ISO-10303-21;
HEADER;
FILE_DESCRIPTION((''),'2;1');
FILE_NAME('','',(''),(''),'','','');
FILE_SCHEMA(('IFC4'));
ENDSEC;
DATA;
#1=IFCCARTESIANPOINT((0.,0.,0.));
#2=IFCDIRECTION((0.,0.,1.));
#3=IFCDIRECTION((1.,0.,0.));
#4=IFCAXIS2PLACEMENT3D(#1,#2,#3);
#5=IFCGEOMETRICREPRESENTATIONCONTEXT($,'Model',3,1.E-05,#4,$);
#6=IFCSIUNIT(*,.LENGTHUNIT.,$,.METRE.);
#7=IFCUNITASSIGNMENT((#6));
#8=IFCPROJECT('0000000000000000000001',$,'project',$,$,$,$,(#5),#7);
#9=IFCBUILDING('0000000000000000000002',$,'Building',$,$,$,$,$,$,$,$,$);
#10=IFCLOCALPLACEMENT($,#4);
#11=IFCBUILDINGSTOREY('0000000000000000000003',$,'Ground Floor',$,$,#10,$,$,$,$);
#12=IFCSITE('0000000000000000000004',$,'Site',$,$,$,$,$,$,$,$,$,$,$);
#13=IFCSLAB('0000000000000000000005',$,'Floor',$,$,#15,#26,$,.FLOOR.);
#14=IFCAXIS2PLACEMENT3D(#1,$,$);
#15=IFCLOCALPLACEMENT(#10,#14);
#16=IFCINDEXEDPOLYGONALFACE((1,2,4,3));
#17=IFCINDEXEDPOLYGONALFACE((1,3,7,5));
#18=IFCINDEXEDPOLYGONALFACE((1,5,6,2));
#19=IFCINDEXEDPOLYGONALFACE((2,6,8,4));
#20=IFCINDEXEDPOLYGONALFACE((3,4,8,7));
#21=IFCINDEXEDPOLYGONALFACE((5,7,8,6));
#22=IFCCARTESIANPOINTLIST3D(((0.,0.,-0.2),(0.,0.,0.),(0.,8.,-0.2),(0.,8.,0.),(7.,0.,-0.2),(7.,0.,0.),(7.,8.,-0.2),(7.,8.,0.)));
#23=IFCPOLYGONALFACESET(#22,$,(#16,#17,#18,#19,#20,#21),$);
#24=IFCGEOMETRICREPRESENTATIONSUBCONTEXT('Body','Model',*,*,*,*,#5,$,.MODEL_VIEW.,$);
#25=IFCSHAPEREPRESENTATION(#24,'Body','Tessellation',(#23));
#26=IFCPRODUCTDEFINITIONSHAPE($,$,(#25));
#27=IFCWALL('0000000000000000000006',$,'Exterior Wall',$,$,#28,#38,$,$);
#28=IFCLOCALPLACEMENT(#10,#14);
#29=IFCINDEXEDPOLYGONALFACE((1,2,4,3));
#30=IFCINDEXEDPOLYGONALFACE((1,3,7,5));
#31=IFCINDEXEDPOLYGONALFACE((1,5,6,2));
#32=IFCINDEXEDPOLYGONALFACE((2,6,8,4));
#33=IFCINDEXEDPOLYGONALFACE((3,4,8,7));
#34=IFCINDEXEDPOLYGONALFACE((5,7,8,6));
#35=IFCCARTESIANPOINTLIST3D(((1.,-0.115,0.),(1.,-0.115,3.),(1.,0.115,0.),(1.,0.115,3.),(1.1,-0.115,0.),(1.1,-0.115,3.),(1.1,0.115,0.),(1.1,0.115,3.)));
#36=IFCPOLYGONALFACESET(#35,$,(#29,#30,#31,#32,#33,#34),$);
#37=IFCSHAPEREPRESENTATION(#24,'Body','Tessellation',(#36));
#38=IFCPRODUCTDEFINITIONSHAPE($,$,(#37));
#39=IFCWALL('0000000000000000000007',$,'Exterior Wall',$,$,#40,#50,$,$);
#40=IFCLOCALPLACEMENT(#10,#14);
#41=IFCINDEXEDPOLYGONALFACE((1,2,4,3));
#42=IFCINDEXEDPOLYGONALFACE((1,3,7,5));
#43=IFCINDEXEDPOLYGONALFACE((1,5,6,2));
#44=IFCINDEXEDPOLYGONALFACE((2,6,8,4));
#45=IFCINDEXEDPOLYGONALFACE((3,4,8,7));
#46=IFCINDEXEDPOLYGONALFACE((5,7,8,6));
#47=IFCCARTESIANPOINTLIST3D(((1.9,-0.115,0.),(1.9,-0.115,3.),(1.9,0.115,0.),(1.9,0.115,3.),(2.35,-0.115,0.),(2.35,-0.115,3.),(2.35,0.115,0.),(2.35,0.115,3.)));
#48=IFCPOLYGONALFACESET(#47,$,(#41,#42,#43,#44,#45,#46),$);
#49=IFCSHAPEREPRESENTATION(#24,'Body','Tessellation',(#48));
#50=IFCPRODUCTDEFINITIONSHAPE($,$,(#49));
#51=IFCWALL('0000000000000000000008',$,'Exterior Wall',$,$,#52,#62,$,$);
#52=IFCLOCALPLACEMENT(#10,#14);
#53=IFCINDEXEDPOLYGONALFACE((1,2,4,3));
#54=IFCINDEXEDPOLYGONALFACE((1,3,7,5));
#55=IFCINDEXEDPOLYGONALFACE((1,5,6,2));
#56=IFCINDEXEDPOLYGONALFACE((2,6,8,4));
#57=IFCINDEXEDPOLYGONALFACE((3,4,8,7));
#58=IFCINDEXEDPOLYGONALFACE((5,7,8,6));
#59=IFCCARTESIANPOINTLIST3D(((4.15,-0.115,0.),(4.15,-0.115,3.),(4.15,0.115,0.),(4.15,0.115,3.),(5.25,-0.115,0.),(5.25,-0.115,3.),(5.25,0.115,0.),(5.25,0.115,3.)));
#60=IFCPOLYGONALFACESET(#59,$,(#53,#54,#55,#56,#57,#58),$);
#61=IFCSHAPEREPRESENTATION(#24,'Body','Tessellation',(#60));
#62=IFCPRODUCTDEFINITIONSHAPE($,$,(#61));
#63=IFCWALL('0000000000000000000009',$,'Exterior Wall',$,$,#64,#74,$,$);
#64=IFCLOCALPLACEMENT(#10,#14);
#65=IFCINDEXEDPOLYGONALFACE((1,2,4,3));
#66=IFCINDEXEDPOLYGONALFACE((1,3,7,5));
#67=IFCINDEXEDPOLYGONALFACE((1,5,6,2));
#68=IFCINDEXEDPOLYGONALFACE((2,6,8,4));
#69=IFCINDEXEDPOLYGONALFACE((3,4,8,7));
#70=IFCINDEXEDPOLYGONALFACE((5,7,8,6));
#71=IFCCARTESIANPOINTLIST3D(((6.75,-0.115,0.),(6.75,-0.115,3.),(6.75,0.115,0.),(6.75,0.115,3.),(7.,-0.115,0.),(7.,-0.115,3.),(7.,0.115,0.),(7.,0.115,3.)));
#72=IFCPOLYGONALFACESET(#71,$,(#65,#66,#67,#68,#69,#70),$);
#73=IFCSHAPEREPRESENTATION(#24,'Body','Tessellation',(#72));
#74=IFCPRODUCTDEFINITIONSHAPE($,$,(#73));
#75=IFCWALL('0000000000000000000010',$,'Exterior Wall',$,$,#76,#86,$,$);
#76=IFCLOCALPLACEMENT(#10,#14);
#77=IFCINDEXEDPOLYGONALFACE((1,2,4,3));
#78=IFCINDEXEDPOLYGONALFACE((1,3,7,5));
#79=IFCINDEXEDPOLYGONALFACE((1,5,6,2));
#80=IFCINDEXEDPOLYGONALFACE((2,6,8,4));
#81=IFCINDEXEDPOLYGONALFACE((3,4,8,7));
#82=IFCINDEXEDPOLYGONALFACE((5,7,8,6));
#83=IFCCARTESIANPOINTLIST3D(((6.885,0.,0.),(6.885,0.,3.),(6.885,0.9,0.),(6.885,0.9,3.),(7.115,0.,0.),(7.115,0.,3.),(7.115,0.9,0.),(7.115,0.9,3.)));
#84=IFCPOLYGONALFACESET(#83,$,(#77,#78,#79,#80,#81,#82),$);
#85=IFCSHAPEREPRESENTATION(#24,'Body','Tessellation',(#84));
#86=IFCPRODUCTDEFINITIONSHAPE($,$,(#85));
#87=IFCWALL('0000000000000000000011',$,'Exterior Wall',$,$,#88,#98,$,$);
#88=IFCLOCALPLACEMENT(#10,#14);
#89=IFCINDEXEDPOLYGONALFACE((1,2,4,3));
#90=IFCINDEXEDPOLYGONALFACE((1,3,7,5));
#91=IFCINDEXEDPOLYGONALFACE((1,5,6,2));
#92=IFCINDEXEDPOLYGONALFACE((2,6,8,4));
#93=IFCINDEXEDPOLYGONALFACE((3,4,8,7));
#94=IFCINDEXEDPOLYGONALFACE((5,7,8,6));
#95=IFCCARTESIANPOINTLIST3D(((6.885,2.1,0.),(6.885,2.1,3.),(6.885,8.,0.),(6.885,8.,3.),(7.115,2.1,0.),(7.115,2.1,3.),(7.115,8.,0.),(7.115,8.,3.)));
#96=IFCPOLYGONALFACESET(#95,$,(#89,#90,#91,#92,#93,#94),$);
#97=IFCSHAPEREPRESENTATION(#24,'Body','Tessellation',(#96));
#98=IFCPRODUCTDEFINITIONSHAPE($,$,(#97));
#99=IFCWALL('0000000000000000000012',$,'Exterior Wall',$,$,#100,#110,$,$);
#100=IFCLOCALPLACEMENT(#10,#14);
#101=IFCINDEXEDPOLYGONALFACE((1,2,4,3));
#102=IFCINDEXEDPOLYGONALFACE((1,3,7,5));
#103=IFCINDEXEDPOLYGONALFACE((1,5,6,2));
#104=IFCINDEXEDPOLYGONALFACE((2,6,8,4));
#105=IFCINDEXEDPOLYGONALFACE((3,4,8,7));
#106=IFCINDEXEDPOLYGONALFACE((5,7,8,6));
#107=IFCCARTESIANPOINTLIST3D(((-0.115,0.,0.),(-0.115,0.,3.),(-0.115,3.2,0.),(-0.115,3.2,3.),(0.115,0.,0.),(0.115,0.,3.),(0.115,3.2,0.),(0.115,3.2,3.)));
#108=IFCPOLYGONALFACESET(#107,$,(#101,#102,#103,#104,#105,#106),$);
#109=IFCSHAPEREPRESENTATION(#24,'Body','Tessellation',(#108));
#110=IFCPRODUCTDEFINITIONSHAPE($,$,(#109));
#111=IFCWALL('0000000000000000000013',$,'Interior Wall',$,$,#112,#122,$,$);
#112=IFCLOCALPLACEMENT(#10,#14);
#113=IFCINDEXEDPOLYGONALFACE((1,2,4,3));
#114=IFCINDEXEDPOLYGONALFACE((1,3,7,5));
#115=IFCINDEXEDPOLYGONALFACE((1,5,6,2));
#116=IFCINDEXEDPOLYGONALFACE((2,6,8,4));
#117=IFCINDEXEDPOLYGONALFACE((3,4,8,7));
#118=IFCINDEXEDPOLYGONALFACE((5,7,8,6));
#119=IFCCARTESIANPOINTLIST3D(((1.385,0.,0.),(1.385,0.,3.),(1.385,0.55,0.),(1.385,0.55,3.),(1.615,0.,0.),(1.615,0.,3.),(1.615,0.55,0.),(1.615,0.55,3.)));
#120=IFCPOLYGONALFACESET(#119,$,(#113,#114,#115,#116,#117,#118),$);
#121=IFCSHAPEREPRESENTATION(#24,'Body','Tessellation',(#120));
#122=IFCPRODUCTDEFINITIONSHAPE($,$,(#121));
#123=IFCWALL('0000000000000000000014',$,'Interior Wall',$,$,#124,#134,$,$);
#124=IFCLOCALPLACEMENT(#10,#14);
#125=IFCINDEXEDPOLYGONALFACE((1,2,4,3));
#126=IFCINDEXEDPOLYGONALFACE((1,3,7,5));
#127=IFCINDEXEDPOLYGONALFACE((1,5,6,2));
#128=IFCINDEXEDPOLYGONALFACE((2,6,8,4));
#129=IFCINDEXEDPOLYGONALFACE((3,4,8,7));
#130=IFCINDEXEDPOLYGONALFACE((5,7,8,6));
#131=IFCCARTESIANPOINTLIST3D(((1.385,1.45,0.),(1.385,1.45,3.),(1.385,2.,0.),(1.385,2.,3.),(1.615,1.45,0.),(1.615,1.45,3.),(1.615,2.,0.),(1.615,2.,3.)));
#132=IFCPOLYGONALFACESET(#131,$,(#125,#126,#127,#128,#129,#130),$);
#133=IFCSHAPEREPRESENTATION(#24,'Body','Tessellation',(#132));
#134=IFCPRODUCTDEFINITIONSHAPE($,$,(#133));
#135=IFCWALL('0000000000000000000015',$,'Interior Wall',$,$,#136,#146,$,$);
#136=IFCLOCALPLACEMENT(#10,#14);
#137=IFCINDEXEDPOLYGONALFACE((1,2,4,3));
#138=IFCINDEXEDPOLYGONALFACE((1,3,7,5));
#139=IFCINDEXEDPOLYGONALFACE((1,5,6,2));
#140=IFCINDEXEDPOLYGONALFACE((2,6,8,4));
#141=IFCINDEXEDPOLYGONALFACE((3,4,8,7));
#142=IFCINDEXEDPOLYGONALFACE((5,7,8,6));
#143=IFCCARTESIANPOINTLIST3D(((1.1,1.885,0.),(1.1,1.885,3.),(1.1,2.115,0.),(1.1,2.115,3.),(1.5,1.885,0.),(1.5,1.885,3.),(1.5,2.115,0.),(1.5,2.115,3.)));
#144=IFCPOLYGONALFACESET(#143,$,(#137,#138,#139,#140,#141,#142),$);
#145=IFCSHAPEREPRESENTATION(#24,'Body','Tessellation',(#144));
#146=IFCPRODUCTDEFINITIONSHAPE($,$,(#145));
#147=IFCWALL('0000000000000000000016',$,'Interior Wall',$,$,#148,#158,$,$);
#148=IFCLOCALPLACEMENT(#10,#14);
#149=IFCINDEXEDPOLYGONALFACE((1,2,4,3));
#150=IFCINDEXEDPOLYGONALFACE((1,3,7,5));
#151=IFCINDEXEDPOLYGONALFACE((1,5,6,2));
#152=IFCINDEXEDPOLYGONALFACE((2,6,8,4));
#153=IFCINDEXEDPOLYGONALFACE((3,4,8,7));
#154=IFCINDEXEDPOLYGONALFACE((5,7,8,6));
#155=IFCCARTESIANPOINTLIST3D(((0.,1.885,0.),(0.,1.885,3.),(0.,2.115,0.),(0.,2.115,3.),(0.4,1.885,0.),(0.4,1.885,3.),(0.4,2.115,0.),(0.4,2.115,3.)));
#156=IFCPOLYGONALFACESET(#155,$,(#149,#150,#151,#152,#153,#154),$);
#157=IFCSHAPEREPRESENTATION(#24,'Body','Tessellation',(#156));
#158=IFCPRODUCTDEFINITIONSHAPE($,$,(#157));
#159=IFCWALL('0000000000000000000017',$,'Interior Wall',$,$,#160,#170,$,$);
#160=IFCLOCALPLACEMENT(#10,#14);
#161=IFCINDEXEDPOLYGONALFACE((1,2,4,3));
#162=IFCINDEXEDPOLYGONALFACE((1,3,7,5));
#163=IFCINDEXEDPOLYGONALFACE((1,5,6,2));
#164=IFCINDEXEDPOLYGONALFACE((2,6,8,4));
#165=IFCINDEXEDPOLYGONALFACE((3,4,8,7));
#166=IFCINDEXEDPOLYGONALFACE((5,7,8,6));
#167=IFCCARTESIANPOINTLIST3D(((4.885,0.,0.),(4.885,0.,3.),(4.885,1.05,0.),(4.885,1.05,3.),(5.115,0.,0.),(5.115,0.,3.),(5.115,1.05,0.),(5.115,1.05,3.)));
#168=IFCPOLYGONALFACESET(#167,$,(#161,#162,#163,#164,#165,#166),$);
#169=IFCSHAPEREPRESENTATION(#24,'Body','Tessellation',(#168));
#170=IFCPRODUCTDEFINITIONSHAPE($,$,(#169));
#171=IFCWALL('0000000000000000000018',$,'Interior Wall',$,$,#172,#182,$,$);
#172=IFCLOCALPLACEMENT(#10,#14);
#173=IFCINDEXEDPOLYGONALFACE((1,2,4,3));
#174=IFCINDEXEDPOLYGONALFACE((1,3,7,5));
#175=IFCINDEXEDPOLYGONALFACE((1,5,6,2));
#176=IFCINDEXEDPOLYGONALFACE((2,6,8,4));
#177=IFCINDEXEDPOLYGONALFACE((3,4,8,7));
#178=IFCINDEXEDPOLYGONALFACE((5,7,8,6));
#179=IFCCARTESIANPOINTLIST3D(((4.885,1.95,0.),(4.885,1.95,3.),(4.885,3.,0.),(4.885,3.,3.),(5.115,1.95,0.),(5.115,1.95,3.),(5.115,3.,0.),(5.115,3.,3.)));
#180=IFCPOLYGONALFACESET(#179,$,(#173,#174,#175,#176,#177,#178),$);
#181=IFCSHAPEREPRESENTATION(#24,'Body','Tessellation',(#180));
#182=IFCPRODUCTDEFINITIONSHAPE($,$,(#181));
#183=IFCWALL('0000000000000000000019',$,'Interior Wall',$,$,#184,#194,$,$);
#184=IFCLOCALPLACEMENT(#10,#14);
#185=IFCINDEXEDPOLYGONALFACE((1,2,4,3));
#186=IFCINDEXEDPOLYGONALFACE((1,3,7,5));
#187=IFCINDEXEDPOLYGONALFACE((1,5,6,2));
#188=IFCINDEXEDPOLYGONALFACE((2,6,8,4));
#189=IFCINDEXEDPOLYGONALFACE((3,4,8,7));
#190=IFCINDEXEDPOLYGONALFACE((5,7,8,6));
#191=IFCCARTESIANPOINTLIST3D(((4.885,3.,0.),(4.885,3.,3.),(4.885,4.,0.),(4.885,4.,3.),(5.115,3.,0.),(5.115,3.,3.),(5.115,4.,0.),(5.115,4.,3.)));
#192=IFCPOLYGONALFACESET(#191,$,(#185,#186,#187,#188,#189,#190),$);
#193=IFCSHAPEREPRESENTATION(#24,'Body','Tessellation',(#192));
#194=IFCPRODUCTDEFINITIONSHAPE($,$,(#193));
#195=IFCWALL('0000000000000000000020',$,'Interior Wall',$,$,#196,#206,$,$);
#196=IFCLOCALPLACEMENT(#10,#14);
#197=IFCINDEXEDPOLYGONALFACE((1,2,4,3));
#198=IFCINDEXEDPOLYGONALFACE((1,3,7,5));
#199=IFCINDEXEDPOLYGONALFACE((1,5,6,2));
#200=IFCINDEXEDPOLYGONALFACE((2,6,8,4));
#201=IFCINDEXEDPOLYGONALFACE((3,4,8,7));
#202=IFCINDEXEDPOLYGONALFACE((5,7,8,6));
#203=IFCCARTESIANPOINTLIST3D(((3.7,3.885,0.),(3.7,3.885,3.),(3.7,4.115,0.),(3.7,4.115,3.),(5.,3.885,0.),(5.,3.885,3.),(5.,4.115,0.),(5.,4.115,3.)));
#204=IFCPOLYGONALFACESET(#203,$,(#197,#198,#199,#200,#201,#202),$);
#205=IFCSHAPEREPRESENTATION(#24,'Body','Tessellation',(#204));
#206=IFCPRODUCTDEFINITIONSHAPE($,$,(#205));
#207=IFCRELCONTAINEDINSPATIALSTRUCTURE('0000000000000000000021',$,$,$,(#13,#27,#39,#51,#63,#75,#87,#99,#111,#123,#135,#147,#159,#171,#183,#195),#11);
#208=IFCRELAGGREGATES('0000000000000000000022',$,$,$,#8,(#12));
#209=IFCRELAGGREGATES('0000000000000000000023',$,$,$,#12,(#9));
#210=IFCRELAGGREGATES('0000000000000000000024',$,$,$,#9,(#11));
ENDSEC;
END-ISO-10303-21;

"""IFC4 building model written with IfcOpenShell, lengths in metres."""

from ifc_helpers import new_model, si_unit, frame, origin_with_axes, place, context, subcontext, project, spatial, indexed_curve, outline, extrude, element, save


model = new_model("IFC4")

# Units and contexts
model_context = context("Model", 3, precision=1e-05, world=origin_with_axes())
body_context = subcontext(model_context, "Body", "Model", "MODEL_VIEW")
ifc_project = project(units=[si_unit("LENGTHUNIT", "METRE")], contexts=[model_context])

# Site, building, storey
site = spatial("IfcSite", under=ifc_project, Name="Site")
building = spatial("IfcBuilding", under=site, Name="Building")
storey_placement = place(None, origin_with_axes())
storey = spatial("IfcBuildingStorey", under=building, at=storey_placement, Name="Ground Floor")

# Slab
slab_placement = place(storey_placement, frame((0.0, 0.0, -0.2), z_axis=(0.0, 0.0, 1.0), x_axis=(1.0, 0.0, 0.0)))
element("IfcSlab", 1, at=slab_placement, inside=storey, Name="Floor", PredefinedType="FLOOR", context=body_context, shape_type="SweptSolid", body=[
    extrude(outline(indexed_curve([(0.0, 0.0), (7.0, 0.0), (7.0, 8.0), (0.0, 8.0)])), None, (0.0, 0.0, 1.0), 0.2),
])

# Walls
wall_1_placement = place(storey_placement, frame((1.0, 0.0, 0.0), z_axis=(0.0, 0.0, 1.0), x_axis=(1.0, 0.0, 0.0)))
element("IfcWall", 2, at=wall_1_placement, inside=storey, Name="Exterior Wall", context=body_context, shape_type="SweptSolid", body=[
    extrude(outline(indexed_curve([(0.0, 0.0), (0.0, 0.23), (0.1, 0.23), (0.1, 0.0), (0.0, 0.0)], self_intersect=False)), frame((0.0, -0.115, 0.0), z_axis=(0.0, 0.0, 1.0), x_axis=(1.0, 0.0, 0.0)), (0.0, 0.0, 1.0), 3.0),
])
wall_2_placement = place(storey_placement, frame((1.9, 0.0, 0.0), z_axis=(0.0, 0.0, 1.0), x_axis=(1.0, 0.0, 0.0)))
element("IfcWall", 3, at=wall_2_placement, inside=storey, Name="Exterior Wall", context=body_context, shape_type="SweptSolid", body=[
    extrude(outline(indexed_curve([(0.0, 0.0), (0.0, 0.23), (0.45, 0.23), (0.45, 0.0), (0.0, 0.0)], self_intersect=False)), frame((0.0, -0.115, 0.0), z_axis=(0.0, 0.0, 1.0), x_axis=(1.0, 0.0, 0.0)), (0.0, 0.0, 1.0), 3.0),
])
wall_3_placement = place(storey_placement, frame((4.15, 0.0, 0.0), z_axis=(0.0, 0.0, 1.0), x_axis=(1.0, 0.0, 0.0)))
element("IfcWall", 4, at=wall_3_placement, inside=storey, Name="Exterior Wall", context=body_context, shape_type="SweptSolid", body=[
    extrude(outline(indexed_curve([(0.0, 0.0), (0.0, 0.23), (1.1, 0.23), (1.1, 0.0), (0.0, 0.0)], self_intersect=False)), frame((0.0, -0.115, 0.0), z_axis=(0.0, 0.0, 1.0), x_axis=(1.0, 0.0, 0.0)), (0.0, 0.0, 1.0), 3.0),
])
wall_4_placement = place(storey_placement, frame((6.75, 0.0, 0.0), z_axis=(0.0, 0.0, 1.0), x_axis=(1.0, 0.0, 0.0)))
element("IfcWall", 5, at=wall_4_placement, inside=storey, Name="Exterior Wall", context=body_context, shape_type="SweptSolid", body=[
    extrude(outline(indexed_curve([(0.0, 0.0), (0.0, 0.23), (0.25, 0.23), (0.25, 0.0), (0.0, 0.0)], self_intersect=False)), frame((0.0, -0.115, 0.0), z_axis=(0.0, 0.0, 1.0), x_axis=(1.0, 0.0, 0.0)), (0.0, 0.0, 1.0), 3.0),
])
wall_5_placement = place(storey_placement, frame((7.0, 0.0, 0.0), z_axis=(0.0, 0.0, 1.0), x_axis=(0.0, 1.0, 0.0)))
element("IfcWall", 6, at=wall_5_placement, inside=storey, Name="Exterior Wall", context=body_context, shape_type="SweptSolid", body=[
    extrude(outline(indexed_curve([(0.0, 0.0), (0.0, 0.23), (0.9, 0.23), (0.9, 0.0), (0.0, 0.0)], self_intersect=False)), frame((0.0, -0.115, 0.0), z_axis=(0.0, 0.0, 1.0), x_axis=(1.0, 0.0, 0.0)), (0.0, 0.0, 1.0), 3.0),
])
wall_6_placement = place(storey_placement, frame((7.0, 2.1, 0.0), z_axis=(0.0, 0.0, 1.0), x_axis=(0.0, 1.0, 0.0)))
element("IfcWall", 7, at=wall_6_placement, inside=storey, Name="Exterior Wall", context=body_context, shape_type="SweptSolid", body=[
    extrude(outline(indexed_curve([(0.0, 0.0), (0.0, 0.23), (5.9, 0.23), (5.9, 0.0), (0.0, 0.0)], self_intersect=False)), frame((0.0, -0.115, 0.0), z_axis=(0.0, 0.0, 1.0), x_axis=(1.0, 0.0, 0.0)), (0.0, 0.0, 1.0), 3.0),
])
wall_7_placement = place(storey_placement, frame((0.0, 3.2, 0.0), z_axis=(0.0, 0.0, 1.0), x_axis=(0.0, -1.0, 0.0)))
element("IfcWall", 8, at=wall_7_placement, inside=storey, Name="Exterior Wall", context=body_context, shape_type="SweptSolid", body=[
    extrude(outline(indexed_curve([(0.0, 0.0), (0.0, 0.23), (3.2, 0.23), (3.2, 0.0), (0.0, 0.0)], self_intersect=False)), frame((0.0, -0.115, 0.0), z_axis=(0.0, 0.0, 1.0), x_axis=(1.0, 0.0, 0.0)), (0.0, 0.0, 1.0), 3.0),
])
for number, where, z_axis, x_axis, name in (
    (9, (1.5, 0.0, 0.0), (0.0, 0.0, 1.0), (0.0, 1.0, 0.0), "Interior Wall"),
    (10, (1.5, 1.45, 0.0), (0.0, 0.0, 1.0), (0.0, 1.0, 0.0), "Interior Wall"),
):
    element("IfcWall", number, at=place(storey_placement, frame(where, z_axis=z_axis, x_axis=x_axis)), inside=storey, Name=name, context=body_context, shape_type="SweptSolid", body=[
        extrude(outline(indexed_curve([(0.0, 0.0), (0.0, 0.23), (0.55, 0.23), (0.55, 0.0), (0.0, 0.0)], self_intersect=False)), frame((0.0, -0.115, 0.0), z_axis=(0.0, 0.0, 1.0), x_axis=(1.0, 0.0, 0.0)), (0.0, 0.0, 1.0), 3.0),
    ])
for number, where, z_axis, x_axis, name in (
    (11, (1.5, 2.0, 0.0), (0.0, 0.0, 1.0), (-1.0, 0.0, 0.0), "Interior Wall"),
    (12, (0.4, 2.0, 0.0), (0.0, 0.0, 1.0), (-1.0, 0.0, 0.0), "Interior Wall"),
):
    element("IfcWall", number, at=place(storey_placement, frame(where, z_axis=z_axis, x_axis=x_axis)), inside=storey, Name=name, context=body_context, shape_type="SweptSolid", body=[
        extrude(outline(indexed_curve([(0.0, 0.0), (0.0, 0.23), (0.4, 0.23), (0.4, 0.0), (0.0, 0.0)], self_intersect=False)), frame((0.0, -0.115, 0.0), z_axis=(0.0, 0.0, 1.0), x_axis=(1.0, 0.0, 0.0)), (0.0, 0.0, 1.0), 3.0),
    ])
for number, where, z_axis, x_axis, name in (
    (13, (5.0, 0.0, 0.0), (0.0, 0.0, 1.0), (0.0, 1.0, 0.0), "Interior Wall"),
    (14, (5.0, 1.95, 0.0), (0.0, 0.0, 1.0), (0.0, 1.0, 0.0), "Interior Wall"),
):
    element("IfcWall", number, at=place(storey_placement, frame(where, z_axis=z_axis, x_axis=x_axis)), inside=storey, Name=name, context=body_context, shape_type="SweptSolid", body=[
        extrude(outline(indexed_curve([(0.0, 0.0), (0.0, 0.23), (1.05, 0.23), (1.05, 0.0), (0.0, 0.0)], self_intersect=False)), frame((0.0, -0.115, 0.0), z_axis=(0.0, 0.0, 1.0), x_axis=(1.0, 0.0, 0.0)), (0.0, 0.0, 1.0), 3.0),
    ])
wall_8_placement = place(storey_placement, frame((5.0, 3.0, 0.0), z_axis=(0.0, 0.0, 1.0), x_axis=(0.0, 1.0, 0.0)))
element("IfcWall", 15, at=wall_8_placement, inside=storey, Name="Interior Wall", context=body_context, shape_type="SweptSolid", body=[
    extrude(outline(indexed_curve([(0.0, 0.0), (0.0, 0.23), (1.0, 0.23), (1.0, 0.0), (0.0, 0.0)], self_intersect=False)), frame((0.0, -0.115, 0.0), z_axis=(0.0, 0.0, 1.0), x_axis=(1.0, 0.0, 0.0)), (0.0, 0.0, 1.0), 3.0),
])
for number, where, z_axis, x_axis, name in (
    (16, (5.0, 4.0, 0.0), (0.0, 0.0, 1.0), (-1.0, 0.0, 0.0), "Interior Wall"),
):
    element("IfcWall", number, at=place(storey_placement, frame(where, z_axis=z_axis, x_axis=x_axis)), inside=storey, Name=name, context=body_context, shape_type="SweptSolid", body=[
        extrude(outline(indexed_curve([(0.0, 0.0), (0.0, 0.23), (1.3, 0.23), (1.3, 0.0), (0.0, 0.0)], self_intersect=False)), frame((0.0, -0.115, 0.0), z_axis=(0.0, 0.0, 1.0), x_axis=(1.0, 0.0, 0.0)), (0.0, 0.0, 1.0), 3.0),
    ])

save(model, "model.ifc")
